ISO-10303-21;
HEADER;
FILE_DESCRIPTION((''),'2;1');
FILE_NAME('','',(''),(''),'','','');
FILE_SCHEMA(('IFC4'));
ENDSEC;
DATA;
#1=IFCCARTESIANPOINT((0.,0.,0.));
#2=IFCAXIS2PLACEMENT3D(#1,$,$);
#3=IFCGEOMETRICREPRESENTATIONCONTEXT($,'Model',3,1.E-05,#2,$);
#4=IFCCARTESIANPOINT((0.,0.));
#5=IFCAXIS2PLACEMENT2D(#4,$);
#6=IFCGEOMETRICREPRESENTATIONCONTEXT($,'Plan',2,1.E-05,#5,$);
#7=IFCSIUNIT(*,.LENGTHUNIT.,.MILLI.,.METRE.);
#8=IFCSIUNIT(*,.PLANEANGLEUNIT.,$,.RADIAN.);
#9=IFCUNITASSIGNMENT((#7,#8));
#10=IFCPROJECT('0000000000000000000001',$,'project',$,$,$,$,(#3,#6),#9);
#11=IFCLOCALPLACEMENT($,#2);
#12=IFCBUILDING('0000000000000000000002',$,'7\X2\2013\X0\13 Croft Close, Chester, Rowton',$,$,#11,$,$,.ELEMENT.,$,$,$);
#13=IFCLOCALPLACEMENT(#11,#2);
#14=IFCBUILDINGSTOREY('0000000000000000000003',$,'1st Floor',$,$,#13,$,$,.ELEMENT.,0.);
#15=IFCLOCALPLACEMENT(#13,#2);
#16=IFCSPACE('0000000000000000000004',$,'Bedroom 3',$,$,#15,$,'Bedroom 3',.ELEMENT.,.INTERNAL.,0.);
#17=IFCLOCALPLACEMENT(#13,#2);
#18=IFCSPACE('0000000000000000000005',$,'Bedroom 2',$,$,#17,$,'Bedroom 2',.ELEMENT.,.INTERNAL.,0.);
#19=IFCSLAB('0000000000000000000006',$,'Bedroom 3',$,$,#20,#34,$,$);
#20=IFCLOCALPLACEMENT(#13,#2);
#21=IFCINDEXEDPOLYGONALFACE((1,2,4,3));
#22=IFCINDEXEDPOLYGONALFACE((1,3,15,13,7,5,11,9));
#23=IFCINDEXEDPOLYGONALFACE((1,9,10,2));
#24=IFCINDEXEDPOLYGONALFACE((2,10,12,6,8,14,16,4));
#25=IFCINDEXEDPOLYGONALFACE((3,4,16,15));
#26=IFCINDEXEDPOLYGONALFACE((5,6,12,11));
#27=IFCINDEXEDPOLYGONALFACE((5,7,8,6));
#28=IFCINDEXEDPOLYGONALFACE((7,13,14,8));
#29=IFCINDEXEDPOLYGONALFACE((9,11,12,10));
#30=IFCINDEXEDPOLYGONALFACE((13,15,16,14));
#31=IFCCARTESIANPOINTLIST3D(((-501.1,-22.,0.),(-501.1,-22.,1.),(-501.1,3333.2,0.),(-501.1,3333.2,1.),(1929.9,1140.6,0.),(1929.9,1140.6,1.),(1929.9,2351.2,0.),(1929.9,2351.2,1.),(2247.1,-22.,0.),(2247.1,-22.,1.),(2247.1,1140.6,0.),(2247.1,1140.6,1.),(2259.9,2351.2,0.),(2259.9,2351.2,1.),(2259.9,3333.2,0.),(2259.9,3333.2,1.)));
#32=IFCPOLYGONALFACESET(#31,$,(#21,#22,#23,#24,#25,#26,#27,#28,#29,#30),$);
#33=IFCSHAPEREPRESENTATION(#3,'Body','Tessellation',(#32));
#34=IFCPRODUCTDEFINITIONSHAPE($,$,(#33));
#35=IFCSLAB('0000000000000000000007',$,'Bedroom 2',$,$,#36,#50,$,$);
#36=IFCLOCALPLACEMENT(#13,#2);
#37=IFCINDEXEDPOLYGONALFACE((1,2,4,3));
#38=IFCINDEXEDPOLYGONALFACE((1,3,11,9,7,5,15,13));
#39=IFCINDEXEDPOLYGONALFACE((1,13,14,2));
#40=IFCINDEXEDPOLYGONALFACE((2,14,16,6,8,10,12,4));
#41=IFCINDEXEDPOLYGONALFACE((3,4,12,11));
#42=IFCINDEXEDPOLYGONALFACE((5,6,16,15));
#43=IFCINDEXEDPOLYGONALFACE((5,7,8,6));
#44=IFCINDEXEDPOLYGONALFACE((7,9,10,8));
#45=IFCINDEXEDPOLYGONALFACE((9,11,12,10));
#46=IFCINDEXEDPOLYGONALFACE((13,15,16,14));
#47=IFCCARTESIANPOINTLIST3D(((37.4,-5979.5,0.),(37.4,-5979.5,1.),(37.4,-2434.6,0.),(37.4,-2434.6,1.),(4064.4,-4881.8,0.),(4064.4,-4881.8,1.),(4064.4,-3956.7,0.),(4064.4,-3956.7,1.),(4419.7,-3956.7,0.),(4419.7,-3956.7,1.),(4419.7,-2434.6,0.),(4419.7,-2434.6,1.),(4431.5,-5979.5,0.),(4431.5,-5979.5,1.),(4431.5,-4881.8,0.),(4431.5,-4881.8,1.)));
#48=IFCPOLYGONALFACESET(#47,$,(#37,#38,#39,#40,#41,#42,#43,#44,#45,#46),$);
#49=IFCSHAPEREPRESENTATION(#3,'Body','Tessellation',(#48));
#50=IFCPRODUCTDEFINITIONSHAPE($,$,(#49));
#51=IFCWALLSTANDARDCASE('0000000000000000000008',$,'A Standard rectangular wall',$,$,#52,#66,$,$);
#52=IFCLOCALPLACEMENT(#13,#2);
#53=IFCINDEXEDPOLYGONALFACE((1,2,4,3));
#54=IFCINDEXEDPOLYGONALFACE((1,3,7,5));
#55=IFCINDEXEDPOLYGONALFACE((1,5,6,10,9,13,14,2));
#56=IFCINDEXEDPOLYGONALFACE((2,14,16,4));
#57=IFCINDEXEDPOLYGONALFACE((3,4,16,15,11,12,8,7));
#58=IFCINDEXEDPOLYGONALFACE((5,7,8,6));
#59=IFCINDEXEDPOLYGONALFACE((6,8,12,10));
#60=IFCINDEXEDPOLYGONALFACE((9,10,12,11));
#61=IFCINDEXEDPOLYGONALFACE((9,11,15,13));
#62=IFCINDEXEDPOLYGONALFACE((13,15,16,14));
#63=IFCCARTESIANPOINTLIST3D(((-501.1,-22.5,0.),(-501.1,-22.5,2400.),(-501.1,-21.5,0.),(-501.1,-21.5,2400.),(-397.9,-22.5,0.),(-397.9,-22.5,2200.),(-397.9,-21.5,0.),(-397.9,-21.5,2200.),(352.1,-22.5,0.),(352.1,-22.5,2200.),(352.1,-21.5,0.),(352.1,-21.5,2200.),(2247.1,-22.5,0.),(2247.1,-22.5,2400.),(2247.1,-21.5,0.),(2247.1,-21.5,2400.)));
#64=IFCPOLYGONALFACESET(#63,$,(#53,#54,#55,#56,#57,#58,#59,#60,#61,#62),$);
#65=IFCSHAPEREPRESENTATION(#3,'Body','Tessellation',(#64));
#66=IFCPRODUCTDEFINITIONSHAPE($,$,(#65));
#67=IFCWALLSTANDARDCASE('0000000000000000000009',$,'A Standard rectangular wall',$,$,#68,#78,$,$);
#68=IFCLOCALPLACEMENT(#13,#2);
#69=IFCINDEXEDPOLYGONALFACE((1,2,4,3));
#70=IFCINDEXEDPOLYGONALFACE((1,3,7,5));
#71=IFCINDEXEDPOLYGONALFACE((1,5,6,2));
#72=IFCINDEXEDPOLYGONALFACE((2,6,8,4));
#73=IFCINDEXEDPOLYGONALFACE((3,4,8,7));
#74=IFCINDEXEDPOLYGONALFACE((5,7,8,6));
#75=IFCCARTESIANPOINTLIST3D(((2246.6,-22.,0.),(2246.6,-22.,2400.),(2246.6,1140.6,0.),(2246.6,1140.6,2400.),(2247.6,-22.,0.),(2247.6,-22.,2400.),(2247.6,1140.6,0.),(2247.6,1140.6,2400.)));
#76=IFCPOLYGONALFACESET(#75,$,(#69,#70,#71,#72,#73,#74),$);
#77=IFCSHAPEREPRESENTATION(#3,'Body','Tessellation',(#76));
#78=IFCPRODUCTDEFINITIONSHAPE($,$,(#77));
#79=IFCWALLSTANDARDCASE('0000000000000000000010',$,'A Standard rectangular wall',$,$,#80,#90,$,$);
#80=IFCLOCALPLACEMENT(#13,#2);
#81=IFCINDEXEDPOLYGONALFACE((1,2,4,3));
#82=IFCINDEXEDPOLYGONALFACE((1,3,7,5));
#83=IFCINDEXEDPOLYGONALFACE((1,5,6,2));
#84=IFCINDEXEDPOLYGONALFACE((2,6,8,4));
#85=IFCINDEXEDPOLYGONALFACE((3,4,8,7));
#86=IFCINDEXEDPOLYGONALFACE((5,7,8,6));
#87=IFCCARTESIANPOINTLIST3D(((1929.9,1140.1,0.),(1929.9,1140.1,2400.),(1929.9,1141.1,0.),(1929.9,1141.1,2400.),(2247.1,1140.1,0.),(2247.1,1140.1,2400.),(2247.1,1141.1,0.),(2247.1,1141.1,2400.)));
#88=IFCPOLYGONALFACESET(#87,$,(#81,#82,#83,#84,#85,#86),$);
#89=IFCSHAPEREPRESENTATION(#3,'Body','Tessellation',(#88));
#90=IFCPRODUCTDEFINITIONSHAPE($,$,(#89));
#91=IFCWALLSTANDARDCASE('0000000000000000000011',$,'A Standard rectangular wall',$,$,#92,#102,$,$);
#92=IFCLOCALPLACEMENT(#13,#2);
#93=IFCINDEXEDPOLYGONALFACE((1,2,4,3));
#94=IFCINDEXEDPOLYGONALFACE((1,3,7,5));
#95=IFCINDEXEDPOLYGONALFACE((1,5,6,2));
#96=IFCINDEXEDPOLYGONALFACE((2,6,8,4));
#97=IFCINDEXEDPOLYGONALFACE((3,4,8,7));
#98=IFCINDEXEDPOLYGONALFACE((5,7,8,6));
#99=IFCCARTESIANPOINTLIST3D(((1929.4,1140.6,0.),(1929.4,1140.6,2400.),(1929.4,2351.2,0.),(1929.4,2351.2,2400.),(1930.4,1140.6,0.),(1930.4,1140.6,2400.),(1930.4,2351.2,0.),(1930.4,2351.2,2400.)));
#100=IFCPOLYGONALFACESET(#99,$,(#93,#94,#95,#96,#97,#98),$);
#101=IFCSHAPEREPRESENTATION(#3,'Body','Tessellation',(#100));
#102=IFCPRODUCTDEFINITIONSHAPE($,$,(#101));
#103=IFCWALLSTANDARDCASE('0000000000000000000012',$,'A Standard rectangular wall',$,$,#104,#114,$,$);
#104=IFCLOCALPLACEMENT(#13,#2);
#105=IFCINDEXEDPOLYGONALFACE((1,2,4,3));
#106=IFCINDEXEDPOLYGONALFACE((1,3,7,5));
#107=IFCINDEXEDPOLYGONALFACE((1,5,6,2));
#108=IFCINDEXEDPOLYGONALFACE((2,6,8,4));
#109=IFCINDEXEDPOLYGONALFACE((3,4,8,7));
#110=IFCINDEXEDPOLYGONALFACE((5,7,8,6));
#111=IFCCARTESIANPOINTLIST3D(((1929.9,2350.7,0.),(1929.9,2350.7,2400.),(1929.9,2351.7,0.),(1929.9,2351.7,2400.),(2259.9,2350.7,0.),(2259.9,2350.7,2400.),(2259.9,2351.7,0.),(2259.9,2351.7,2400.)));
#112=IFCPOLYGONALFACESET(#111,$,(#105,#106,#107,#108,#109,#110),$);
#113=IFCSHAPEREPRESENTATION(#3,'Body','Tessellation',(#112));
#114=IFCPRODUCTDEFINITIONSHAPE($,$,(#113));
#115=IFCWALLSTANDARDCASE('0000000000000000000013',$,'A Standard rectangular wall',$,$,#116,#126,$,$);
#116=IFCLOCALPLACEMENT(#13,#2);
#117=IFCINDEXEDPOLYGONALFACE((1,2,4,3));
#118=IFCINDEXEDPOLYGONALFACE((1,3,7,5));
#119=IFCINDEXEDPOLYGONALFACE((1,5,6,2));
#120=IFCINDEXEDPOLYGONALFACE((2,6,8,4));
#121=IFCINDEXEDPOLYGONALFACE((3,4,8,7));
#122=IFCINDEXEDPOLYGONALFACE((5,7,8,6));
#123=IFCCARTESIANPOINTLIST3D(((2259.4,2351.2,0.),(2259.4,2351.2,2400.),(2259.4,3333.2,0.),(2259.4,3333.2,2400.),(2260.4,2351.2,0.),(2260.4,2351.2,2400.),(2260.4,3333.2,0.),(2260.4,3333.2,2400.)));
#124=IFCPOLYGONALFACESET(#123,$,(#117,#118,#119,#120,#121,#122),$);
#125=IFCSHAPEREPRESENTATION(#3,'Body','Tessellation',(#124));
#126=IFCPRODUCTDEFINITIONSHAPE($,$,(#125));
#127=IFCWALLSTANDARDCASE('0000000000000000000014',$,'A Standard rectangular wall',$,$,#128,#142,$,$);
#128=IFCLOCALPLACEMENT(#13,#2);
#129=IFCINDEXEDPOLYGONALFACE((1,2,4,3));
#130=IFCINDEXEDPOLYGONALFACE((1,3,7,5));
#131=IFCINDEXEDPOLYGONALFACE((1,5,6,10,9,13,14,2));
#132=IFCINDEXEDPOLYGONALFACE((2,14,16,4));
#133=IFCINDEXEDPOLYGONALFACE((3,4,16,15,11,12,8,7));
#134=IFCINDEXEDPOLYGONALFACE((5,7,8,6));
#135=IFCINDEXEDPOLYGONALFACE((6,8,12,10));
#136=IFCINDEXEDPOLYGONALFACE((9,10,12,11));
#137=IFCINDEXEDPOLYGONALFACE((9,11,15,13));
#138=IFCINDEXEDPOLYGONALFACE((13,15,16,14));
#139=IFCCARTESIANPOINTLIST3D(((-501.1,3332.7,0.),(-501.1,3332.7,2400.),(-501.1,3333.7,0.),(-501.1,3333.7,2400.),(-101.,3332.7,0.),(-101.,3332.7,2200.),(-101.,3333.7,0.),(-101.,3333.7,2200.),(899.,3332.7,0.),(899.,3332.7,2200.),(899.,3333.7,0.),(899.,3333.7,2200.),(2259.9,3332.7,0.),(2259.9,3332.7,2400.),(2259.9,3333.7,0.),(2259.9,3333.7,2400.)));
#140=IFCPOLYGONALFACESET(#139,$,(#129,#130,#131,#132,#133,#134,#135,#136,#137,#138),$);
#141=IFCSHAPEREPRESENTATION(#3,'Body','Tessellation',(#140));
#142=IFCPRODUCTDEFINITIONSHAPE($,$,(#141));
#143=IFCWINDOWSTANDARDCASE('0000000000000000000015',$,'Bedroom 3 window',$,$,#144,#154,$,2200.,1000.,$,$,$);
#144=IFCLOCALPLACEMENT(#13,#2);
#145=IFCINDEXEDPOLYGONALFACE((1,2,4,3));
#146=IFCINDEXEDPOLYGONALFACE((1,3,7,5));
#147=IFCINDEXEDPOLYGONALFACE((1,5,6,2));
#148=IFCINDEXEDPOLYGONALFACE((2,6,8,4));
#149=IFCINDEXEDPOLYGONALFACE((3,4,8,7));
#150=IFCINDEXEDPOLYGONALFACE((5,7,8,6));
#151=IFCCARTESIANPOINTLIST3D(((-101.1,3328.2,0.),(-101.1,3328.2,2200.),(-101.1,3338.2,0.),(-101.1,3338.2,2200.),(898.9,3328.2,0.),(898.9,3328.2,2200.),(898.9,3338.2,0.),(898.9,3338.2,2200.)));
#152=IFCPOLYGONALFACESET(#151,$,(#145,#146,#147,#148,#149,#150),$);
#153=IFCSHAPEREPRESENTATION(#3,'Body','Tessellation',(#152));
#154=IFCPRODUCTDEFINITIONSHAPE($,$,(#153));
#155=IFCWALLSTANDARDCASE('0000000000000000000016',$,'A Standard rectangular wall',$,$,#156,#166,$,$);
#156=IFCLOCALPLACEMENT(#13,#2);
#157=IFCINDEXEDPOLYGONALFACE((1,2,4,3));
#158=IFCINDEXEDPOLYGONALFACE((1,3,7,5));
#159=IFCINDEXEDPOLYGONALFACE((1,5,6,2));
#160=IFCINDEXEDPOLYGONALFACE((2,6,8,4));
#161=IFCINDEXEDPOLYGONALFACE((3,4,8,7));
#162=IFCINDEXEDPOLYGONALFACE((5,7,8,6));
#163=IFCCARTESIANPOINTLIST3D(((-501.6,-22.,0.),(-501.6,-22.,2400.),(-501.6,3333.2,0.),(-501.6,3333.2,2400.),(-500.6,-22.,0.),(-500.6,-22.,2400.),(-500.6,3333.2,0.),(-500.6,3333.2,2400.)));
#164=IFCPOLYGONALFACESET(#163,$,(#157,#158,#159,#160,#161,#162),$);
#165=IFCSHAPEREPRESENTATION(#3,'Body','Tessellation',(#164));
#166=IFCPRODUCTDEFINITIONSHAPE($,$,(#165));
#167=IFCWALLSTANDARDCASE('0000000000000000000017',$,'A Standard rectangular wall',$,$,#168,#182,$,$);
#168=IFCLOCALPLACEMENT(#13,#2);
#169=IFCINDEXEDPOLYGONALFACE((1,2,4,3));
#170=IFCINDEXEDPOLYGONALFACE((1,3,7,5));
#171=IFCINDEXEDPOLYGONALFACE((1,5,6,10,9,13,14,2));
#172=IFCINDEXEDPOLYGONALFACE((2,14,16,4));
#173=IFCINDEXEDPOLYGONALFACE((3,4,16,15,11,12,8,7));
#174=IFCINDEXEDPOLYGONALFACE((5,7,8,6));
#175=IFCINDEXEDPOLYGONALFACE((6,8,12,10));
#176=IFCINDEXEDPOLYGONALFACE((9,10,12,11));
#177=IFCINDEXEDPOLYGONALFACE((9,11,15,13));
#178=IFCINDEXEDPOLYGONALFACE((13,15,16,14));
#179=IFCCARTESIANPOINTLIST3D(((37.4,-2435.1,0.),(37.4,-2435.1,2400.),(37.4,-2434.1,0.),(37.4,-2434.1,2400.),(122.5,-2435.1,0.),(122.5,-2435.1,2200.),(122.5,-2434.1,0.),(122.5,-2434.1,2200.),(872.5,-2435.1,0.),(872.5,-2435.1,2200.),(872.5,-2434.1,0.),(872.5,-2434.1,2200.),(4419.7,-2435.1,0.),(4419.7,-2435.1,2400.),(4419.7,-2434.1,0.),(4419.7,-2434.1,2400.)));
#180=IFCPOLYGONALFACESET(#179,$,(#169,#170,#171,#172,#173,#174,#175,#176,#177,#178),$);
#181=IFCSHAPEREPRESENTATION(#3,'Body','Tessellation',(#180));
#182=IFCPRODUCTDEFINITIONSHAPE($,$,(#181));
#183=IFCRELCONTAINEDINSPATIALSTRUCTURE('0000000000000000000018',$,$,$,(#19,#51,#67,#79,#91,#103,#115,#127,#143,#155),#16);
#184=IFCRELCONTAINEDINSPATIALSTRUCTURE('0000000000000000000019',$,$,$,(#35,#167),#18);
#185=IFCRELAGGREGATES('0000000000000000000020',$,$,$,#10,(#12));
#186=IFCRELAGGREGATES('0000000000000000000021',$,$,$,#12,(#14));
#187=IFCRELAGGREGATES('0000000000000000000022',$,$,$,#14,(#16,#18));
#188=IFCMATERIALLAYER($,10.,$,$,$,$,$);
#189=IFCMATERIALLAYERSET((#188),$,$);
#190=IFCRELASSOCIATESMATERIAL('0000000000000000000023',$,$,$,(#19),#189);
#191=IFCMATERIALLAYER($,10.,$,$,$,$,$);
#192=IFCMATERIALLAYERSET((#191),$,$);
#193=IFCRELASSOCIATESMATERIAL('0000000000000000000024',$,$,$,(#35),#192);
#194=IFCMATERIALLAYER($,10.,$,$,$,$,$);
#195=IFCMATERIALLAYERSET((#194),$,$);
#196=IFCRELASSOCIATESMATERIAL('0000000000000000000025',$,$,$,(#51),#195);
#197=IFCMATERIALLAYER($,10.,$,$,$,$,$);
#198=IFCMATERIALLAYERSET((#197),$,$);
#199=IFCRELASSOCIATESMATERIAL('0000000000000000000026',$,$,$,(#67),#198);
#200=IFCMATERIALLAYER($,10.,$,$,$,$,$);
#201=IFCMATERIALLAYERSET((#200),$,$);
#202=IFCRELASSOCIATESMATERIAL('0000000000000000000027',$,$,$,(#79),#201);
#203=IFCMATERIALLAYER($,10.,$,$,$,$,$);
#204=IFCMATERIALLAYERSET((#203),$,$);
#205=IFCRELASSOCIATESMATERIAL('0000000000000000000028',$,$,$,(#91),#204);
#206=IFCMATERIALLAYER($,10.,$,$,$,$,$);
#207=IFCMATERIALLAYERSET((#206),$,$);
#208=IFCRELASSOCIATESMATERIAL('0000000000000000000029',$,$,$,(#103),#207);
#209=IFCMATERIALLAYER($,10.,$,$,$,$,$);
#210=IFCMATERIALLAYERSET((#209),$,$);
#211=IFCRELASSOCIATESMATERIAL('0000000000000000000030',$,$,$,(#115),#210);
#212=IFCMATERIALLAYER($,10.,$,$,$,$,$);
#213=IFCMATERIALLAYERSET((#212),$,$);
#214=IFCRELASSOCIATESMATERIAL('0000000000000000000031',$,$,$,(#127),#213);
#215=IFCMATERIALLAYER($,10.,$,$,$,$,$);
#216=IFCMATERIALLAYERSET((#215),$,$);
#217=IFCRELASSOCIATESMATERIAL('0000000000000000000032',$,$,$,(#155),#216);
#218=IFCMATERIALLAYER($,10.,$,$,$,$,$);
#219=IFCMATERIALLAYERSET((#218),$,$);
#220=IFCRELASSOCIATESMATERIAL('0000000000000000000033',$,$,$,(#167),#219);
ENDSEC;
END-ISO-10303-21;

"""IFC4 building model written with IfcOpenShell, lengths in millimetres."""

from ifc_helpers import new_model, si_unit, frame, origin, origin_2d, place, context, project, spatial, polyline, rectangle, outline, extrude, layer, layer_set, layer_usage, element, fill, save


model = new_model("IFC4")

# Units and contexts
model_context = context("Model", 3, precision=1e-05, world=origin())
plan_context = context("Plan", 2, precision=1e-05, world=origin_2d())
ifc_project = project(units=[si_unit("LENGTHUNIT", "METRE", prefix="MILLI"), si_unit("PLANEANGLEUNIT", "RADIAN")], contexts=[model_context, plan_context])

# Building, storey, space
building_placement = place(None, origin())
building = spatial("IfcBuilding", under=ifc_project, at=building_placement, Name="7–13 Croft Close, Chester, Rowton", CompositionType="ELEMENT")
storey_placement = place(building_placement, origin())
storey = spatial("IfcBuildingStorey", under=building, at=storey_placement, Name="1st Floor", CompositionType="ELEMENT", Elevation=0.0)
space_1_placement = place(storey_placement, origin())
space_1 = spatial("IfcSpace", under=storey, at=space_1_placement, Name="Bedroom 3", LongName="Bedroom 3", CompositionType="ELEMENT", PredefinedType="INTERNAL", ElevationWithFlooring=0.0)

# Slab
ifc_layer_1 = layer(None, 10.0)
ifc_layer_set_1 = layer_set([ifc_layer_1])
ifc_layer_usage_1 = layer_usage(ifc_layer_set_1, "AXIS2", "NEGATIVE", 150.0)
slab_1_placement = place(storey_placement, origin())
element("IfcSlab", 1, at=slab_1_placement, inside=space_1, material=ifc_layer_usage_1, Name="Bedroom 3", context=model_context, shape_type="SweptSolid", body=[
    extrude(outline(polyline([(-501.1, 3333.2), (-501.1, -22.0), (2247.1, -22.0), (2247.1, 1140.6), (1929.9, 1140.6), (1929.9, 2351.2), (2259.9, 2351.2), (2259.9, 3333.2), (-501.1, 3333.2)])), origin(), (0.0, 0.0, 1.0), 1.0),
])

# Shared definitions
space_2_placement = place(storey_placement, origin())
space_2 = spatial("IfcSpace", under=storey, at=space_2_placement, Name="Bedroom 2", LongName="Bedroom 2", CompositionType="ELEMENT", PredefinedType="INTERNAL", ElevationWithFlooring=0.0)

# Slab
ifc_layer_2 = layer(None, 10.0)
ifc_layer_set_2 = layer_set([ifc_layer_2])
ifc_layer_usage_2 = layer_usage(ifc_layer_set_2, "AXIS2", "NEGATIVE", 150.0)
slab_2_placement = place(storey_placement, origin())
element("IfcSlab", 2, at=slab_2_placement, inside=space_2, material=ifc_layer_usage_2, Name="Bedroom 2", context=model_context, shape_type="SweptSolid", body=[
    extrude(outline(polyline([(4419.7, -2434.6), (37.4, -2434.6), (37.4, -5979.5), (4431.5, -5979.5), (4431.5, -4881.8), (4064.4, -4881.8), (4064.4, -3956.7), (4419.7, -3956.7), (4419.7, -2434.6)])), origin(), (0.0, 0.0, 1.0), 1.0),
])

# Wall, opening
ifc_layer_3 = layer(None, 10.0)
ifc_layer_set_3 = layer_set([ifc_layer_3])
ifc_layer_usage_3 = layer_usage(ifc_layer_set_3, "AXIS2", "NEGATIVE", 150.0)
wall_1_placement = place(storey_placement, origin())
wall_1 = element("IfcWallStandardCase", 3, at=wall_1_placement, inside=space_1, material=ifc_layer_usage_3, Name="A Standard rectangular wall", context=model_context, shape_type="SweptSolid", body=[
    extrude(rectangle(XDim=1.0, YDim=2748.2, at=origin_2d()), frame((873.0, -22.0, 0.0), x_axis=(0.0, 1.0, 0.0)), (0.0, 0.0, 1.0), 2400.0),
])
opening_1_placement = place(storey_placement, origin())
element("IfcOpeningElement", 4, at=opening_1_placement, cuts=wall_1, context=model_context, shape_type="SweptSolid", body=[
    extrude(rectangle(XDim=10.0, YDim=750.0, at=origin_2d()), frame((-22.9, -22.0, 0.0), x_axis=(0.0, -1.0, 0.0)), (0.0, 0.0, 1.0), 2200.0),
])

# Walls
ifc_layer_4 = layer(None, 10.0)
ifc_layer_set_4 = layer_set([ifc_layer_4])
ifc_layer_usage_4 = layer_usage(ifc_layer_set_4, "AXIS2", "NEGATIVE", 150.0)
wall_2_placement = place(storey_placement, origin())
element("IfcWallStandardCase", 5, at=wall_2_placement, inside=space_1, material=ifc_layer_usage_4, Name="A Standard rectangular wall", context=model_context, shape_type="SweptSolid", body=[
    extrude(rectangle(XDim=1.0, YDim=1162.6, at=origin_2d()), frame((2247.1, 559.3, 0.0), x_axis=(-1.0, 0.0, 0.0)), (0.0, 0.0, 1.0), 2400.0),
])
ifc_layer_5 = layer(None, 10.0)
ifc_layer_set_5 = layer_set([ifc_layer_5])
ifc_layer_usage_5 = layer_usage(ifc_layer_set_5, "AXIS2", "NEGATIVE", 150.0)
wall_3_placement = place(storey_placement, origin())
element("IfcWallStandardCase", 6, at=wall_3_placement, inside=space_1, material=ifc_layer_usage_5, Name="A Standard rectangular wall", context=model_context, shape_type="SweptSolid", body=[
    extrude(rectangle(XDim=1.0, YDim=317.2, at=origin_2d()), frame((2088.5, 1140.6, 0.0), x_axis=(0.0, -1.0, 0.0)), (0.0, 0.0, 1.0), 2400.0),
])
ifc_layer_6 = layer(None, 10.0)
ifc_layer_set_6 = layer_set([ifc_layer_6])
ifc_layer_usage_6 = layer_usage(ifc_layer_set_6, "AXIS2", "NEGATIVE", 150.0)
wall_4_placement = place(storey_placement, origin())
element("IfcWallStandardCase", 7, at=wall_4_placement, inside=space_1, material=ifc_layer_usage_6, Name="A Standard rectangular wall", context=model_context, shape_type="SweptSolid", body=[
    extrude(rectangle(XDim=1.0, YDim=1210.6, at=origin_2d()), frame((1929.9, 1745.9, 0.0), x_axis=(-1.0, 0.0, 0.0)), (0.0, 0.0, 1.0), 2400.0),
])
ifc_layer_7 = layer(None, 10.0)
ifc_layer_set_7 = layer_set([ifc_layer_7])
ifc_layer_usage_7 = layer_usage(ifc_layer_set_7, "AXIS2", "NEGATIVE", 150.0)
wall_5_placement = place(storey_placement, origin())
element("IfcWallStandardCase", 8, at=wall_5_placement, inside=space_1, material=ifc_layer_usage_7, Name="A Standard rectangular wall", context=model_context, shape_type="SweptSolid", body=[
    extrude(rectangle(XDim=1.0, YDim=330.0, at=origin_2d()), frame((2094.9, 2351.2, 0.0), x_axis=(0.0, 1.0, 0.0)), (0.0, 0.0, 1.0), 2400.0),
])
ifc_layer_8 = layer(None, 10.0)
ifc_layer_set_8 = layer_set([ifc_layer_8])
ifc_layer_usage_8 = layer_usage(ifc_layer_set_8, "AXIS2", "NEGATIVE", 150.0)
wall_6_placement = place(storey_placement, origin())
element("IfcWallStandardCase", 9, at=wall_6_placement, inside=space_1, material=ifc_layer_usage_8, Name="A Standard rectangular wall", context=model_context, shape_type="SweptSolid", body=[
    extrude(rectangle(XDim=1.0, YDim=982.0, at=origin_2d()), frame((2259.9, 2842.2, 0.0), x_axis=(-1.0, 0.0, 0.0)), (0.0, 0.0, 1.0), 2400.0),
])

# Wall, opening, window
ifc_layer_9 = layer(None, 10.0)
ifc_layer_set_9 = layer_set([ifc_layer_9])
ifc_layer_usage_9 = layer_usage(ifc_layer_set_9, "AXIS2", "NEGATIVE", 150.0)
wall_7_placement = place(storey_placement, origin())
wall_7 = element("IfcWallStandardCase", 10, at=wall_7_placement, inside=space_1, material=ifc_layer_usage_9, Name="A Standard rectangular wall", context=model_context, shape_type="SweptSolid", body=[
    extrude(rectangle(XDim=1.0, YDim=2761.0, at=origin_2d()), frame((879.4, 3333.2, 0.0), x_axis=(0.0, -1.0, 0.0)), (0.0, 0.0, 1.0), 2400.0),
])
opening_2_placement = place(storey_placement, origin())
opening_2 = element("IfcOpeningElement", 11, at=opening_2_placement, cuts=wall_7, context=model_context, shape_type="SweptSolid", body=[
    extrude(rectangle(XDim=10.0, YDim=1000.0, at=origin_2d()), frame((399.0, 3333.2, 0.0), x_axis=(0.0, -1.0, 0.0)), (0.0, 0.0, 1.0), 2200.0),
])
window_1_placement = place(storey_placement, frame((-0.1, 0.0, 0.0)))
window_1 = element("IfcWindowStandardCase", 12, at=window_1_placement, inside=space_1, Name="Bedroom 3 window", OverallHeight=2200.0, OverallWidth=1000.0, context=model_context, shape_type="SweptSolid", body=[
    extrude(rectangle(XDim=10.0, YDim=1000.0, at=origin_2d()), frame((399.0, 3333.2, 0.0), x_axis=(0.0, -1.0, 0.0)), (0.0, 0.0, 1.0), 2200.0),
])
fill(opening_2, window_1)

# Wall
ifc_layer_10 = layer(None, 10.0)
ifc_layer_set_10 = layer_set([ifc_layer_10])
ifc_layer_usage_10 = layer_usage(ifc_layer_set_10, "AXIS2", "NEGATIVE", 150.0)
wall_8_placement = place(storey_placement, origin())
element("IfcWallStandardCase", 13, at=wall_8_placement, inside=space_1, material=ifc_layer_usage_10, Name="A Standard rectangular wall", context=model_context, shape_type="SweptSolid", body=[
    extrude(rectangle(XDim=1.0, YDim=3355.2, at=origin_2d()), frame((-501.1, 1655.6, 0.0), x_axis=(1.0, 0.0, 0.0)), (0.0, 0.0, 1.0), 2400.0),
])

# Wall, opening
ifc_layer_11 = layer(None, 10.0)
ifc_layer_set_11 = layer_set([ifc_layer_11])
ifc_layer_usage_11 = layer_usage(ifc_layer_set_11, "AXIS2", "NEGATIVE", 150.0)
wall_9_placement = place(storey_placement, origin())
wall_9 = element("IfcWallStandardCase", 14, at=wall_9_placement, inside=space_2, material=ifc_layer_usage_11, Name="A Standard rectangular wall", context=model_context, shape_type="SweptSolid", body=[
    extrude(rectangle(XDim=1.0, YDim=4382.3, at=origin_2d()), frame((2228.6, -2434.6, 0.0), x_axis=(0.0, -1.0, 0.0)), (0.0, 0.0, 1.0), 2400.0),
])
opening_3_placement = place(storey_placement, origin())
element("IfcOpeningElement", 15, at=opening_3_placement, cuts=wall_9, context=model_context, shape_type="SweptSolid", body=[
    extrude(rectangle(XDim=10.0, YDim=750.0, at=origin_2d()), frame((497.5, -2434.6, 0.0), x_axis=(0.0, 1.0, 0.0)), (0.0, 0.0, 1.0), 2200.0),
])

save(model, "model.ifc")
